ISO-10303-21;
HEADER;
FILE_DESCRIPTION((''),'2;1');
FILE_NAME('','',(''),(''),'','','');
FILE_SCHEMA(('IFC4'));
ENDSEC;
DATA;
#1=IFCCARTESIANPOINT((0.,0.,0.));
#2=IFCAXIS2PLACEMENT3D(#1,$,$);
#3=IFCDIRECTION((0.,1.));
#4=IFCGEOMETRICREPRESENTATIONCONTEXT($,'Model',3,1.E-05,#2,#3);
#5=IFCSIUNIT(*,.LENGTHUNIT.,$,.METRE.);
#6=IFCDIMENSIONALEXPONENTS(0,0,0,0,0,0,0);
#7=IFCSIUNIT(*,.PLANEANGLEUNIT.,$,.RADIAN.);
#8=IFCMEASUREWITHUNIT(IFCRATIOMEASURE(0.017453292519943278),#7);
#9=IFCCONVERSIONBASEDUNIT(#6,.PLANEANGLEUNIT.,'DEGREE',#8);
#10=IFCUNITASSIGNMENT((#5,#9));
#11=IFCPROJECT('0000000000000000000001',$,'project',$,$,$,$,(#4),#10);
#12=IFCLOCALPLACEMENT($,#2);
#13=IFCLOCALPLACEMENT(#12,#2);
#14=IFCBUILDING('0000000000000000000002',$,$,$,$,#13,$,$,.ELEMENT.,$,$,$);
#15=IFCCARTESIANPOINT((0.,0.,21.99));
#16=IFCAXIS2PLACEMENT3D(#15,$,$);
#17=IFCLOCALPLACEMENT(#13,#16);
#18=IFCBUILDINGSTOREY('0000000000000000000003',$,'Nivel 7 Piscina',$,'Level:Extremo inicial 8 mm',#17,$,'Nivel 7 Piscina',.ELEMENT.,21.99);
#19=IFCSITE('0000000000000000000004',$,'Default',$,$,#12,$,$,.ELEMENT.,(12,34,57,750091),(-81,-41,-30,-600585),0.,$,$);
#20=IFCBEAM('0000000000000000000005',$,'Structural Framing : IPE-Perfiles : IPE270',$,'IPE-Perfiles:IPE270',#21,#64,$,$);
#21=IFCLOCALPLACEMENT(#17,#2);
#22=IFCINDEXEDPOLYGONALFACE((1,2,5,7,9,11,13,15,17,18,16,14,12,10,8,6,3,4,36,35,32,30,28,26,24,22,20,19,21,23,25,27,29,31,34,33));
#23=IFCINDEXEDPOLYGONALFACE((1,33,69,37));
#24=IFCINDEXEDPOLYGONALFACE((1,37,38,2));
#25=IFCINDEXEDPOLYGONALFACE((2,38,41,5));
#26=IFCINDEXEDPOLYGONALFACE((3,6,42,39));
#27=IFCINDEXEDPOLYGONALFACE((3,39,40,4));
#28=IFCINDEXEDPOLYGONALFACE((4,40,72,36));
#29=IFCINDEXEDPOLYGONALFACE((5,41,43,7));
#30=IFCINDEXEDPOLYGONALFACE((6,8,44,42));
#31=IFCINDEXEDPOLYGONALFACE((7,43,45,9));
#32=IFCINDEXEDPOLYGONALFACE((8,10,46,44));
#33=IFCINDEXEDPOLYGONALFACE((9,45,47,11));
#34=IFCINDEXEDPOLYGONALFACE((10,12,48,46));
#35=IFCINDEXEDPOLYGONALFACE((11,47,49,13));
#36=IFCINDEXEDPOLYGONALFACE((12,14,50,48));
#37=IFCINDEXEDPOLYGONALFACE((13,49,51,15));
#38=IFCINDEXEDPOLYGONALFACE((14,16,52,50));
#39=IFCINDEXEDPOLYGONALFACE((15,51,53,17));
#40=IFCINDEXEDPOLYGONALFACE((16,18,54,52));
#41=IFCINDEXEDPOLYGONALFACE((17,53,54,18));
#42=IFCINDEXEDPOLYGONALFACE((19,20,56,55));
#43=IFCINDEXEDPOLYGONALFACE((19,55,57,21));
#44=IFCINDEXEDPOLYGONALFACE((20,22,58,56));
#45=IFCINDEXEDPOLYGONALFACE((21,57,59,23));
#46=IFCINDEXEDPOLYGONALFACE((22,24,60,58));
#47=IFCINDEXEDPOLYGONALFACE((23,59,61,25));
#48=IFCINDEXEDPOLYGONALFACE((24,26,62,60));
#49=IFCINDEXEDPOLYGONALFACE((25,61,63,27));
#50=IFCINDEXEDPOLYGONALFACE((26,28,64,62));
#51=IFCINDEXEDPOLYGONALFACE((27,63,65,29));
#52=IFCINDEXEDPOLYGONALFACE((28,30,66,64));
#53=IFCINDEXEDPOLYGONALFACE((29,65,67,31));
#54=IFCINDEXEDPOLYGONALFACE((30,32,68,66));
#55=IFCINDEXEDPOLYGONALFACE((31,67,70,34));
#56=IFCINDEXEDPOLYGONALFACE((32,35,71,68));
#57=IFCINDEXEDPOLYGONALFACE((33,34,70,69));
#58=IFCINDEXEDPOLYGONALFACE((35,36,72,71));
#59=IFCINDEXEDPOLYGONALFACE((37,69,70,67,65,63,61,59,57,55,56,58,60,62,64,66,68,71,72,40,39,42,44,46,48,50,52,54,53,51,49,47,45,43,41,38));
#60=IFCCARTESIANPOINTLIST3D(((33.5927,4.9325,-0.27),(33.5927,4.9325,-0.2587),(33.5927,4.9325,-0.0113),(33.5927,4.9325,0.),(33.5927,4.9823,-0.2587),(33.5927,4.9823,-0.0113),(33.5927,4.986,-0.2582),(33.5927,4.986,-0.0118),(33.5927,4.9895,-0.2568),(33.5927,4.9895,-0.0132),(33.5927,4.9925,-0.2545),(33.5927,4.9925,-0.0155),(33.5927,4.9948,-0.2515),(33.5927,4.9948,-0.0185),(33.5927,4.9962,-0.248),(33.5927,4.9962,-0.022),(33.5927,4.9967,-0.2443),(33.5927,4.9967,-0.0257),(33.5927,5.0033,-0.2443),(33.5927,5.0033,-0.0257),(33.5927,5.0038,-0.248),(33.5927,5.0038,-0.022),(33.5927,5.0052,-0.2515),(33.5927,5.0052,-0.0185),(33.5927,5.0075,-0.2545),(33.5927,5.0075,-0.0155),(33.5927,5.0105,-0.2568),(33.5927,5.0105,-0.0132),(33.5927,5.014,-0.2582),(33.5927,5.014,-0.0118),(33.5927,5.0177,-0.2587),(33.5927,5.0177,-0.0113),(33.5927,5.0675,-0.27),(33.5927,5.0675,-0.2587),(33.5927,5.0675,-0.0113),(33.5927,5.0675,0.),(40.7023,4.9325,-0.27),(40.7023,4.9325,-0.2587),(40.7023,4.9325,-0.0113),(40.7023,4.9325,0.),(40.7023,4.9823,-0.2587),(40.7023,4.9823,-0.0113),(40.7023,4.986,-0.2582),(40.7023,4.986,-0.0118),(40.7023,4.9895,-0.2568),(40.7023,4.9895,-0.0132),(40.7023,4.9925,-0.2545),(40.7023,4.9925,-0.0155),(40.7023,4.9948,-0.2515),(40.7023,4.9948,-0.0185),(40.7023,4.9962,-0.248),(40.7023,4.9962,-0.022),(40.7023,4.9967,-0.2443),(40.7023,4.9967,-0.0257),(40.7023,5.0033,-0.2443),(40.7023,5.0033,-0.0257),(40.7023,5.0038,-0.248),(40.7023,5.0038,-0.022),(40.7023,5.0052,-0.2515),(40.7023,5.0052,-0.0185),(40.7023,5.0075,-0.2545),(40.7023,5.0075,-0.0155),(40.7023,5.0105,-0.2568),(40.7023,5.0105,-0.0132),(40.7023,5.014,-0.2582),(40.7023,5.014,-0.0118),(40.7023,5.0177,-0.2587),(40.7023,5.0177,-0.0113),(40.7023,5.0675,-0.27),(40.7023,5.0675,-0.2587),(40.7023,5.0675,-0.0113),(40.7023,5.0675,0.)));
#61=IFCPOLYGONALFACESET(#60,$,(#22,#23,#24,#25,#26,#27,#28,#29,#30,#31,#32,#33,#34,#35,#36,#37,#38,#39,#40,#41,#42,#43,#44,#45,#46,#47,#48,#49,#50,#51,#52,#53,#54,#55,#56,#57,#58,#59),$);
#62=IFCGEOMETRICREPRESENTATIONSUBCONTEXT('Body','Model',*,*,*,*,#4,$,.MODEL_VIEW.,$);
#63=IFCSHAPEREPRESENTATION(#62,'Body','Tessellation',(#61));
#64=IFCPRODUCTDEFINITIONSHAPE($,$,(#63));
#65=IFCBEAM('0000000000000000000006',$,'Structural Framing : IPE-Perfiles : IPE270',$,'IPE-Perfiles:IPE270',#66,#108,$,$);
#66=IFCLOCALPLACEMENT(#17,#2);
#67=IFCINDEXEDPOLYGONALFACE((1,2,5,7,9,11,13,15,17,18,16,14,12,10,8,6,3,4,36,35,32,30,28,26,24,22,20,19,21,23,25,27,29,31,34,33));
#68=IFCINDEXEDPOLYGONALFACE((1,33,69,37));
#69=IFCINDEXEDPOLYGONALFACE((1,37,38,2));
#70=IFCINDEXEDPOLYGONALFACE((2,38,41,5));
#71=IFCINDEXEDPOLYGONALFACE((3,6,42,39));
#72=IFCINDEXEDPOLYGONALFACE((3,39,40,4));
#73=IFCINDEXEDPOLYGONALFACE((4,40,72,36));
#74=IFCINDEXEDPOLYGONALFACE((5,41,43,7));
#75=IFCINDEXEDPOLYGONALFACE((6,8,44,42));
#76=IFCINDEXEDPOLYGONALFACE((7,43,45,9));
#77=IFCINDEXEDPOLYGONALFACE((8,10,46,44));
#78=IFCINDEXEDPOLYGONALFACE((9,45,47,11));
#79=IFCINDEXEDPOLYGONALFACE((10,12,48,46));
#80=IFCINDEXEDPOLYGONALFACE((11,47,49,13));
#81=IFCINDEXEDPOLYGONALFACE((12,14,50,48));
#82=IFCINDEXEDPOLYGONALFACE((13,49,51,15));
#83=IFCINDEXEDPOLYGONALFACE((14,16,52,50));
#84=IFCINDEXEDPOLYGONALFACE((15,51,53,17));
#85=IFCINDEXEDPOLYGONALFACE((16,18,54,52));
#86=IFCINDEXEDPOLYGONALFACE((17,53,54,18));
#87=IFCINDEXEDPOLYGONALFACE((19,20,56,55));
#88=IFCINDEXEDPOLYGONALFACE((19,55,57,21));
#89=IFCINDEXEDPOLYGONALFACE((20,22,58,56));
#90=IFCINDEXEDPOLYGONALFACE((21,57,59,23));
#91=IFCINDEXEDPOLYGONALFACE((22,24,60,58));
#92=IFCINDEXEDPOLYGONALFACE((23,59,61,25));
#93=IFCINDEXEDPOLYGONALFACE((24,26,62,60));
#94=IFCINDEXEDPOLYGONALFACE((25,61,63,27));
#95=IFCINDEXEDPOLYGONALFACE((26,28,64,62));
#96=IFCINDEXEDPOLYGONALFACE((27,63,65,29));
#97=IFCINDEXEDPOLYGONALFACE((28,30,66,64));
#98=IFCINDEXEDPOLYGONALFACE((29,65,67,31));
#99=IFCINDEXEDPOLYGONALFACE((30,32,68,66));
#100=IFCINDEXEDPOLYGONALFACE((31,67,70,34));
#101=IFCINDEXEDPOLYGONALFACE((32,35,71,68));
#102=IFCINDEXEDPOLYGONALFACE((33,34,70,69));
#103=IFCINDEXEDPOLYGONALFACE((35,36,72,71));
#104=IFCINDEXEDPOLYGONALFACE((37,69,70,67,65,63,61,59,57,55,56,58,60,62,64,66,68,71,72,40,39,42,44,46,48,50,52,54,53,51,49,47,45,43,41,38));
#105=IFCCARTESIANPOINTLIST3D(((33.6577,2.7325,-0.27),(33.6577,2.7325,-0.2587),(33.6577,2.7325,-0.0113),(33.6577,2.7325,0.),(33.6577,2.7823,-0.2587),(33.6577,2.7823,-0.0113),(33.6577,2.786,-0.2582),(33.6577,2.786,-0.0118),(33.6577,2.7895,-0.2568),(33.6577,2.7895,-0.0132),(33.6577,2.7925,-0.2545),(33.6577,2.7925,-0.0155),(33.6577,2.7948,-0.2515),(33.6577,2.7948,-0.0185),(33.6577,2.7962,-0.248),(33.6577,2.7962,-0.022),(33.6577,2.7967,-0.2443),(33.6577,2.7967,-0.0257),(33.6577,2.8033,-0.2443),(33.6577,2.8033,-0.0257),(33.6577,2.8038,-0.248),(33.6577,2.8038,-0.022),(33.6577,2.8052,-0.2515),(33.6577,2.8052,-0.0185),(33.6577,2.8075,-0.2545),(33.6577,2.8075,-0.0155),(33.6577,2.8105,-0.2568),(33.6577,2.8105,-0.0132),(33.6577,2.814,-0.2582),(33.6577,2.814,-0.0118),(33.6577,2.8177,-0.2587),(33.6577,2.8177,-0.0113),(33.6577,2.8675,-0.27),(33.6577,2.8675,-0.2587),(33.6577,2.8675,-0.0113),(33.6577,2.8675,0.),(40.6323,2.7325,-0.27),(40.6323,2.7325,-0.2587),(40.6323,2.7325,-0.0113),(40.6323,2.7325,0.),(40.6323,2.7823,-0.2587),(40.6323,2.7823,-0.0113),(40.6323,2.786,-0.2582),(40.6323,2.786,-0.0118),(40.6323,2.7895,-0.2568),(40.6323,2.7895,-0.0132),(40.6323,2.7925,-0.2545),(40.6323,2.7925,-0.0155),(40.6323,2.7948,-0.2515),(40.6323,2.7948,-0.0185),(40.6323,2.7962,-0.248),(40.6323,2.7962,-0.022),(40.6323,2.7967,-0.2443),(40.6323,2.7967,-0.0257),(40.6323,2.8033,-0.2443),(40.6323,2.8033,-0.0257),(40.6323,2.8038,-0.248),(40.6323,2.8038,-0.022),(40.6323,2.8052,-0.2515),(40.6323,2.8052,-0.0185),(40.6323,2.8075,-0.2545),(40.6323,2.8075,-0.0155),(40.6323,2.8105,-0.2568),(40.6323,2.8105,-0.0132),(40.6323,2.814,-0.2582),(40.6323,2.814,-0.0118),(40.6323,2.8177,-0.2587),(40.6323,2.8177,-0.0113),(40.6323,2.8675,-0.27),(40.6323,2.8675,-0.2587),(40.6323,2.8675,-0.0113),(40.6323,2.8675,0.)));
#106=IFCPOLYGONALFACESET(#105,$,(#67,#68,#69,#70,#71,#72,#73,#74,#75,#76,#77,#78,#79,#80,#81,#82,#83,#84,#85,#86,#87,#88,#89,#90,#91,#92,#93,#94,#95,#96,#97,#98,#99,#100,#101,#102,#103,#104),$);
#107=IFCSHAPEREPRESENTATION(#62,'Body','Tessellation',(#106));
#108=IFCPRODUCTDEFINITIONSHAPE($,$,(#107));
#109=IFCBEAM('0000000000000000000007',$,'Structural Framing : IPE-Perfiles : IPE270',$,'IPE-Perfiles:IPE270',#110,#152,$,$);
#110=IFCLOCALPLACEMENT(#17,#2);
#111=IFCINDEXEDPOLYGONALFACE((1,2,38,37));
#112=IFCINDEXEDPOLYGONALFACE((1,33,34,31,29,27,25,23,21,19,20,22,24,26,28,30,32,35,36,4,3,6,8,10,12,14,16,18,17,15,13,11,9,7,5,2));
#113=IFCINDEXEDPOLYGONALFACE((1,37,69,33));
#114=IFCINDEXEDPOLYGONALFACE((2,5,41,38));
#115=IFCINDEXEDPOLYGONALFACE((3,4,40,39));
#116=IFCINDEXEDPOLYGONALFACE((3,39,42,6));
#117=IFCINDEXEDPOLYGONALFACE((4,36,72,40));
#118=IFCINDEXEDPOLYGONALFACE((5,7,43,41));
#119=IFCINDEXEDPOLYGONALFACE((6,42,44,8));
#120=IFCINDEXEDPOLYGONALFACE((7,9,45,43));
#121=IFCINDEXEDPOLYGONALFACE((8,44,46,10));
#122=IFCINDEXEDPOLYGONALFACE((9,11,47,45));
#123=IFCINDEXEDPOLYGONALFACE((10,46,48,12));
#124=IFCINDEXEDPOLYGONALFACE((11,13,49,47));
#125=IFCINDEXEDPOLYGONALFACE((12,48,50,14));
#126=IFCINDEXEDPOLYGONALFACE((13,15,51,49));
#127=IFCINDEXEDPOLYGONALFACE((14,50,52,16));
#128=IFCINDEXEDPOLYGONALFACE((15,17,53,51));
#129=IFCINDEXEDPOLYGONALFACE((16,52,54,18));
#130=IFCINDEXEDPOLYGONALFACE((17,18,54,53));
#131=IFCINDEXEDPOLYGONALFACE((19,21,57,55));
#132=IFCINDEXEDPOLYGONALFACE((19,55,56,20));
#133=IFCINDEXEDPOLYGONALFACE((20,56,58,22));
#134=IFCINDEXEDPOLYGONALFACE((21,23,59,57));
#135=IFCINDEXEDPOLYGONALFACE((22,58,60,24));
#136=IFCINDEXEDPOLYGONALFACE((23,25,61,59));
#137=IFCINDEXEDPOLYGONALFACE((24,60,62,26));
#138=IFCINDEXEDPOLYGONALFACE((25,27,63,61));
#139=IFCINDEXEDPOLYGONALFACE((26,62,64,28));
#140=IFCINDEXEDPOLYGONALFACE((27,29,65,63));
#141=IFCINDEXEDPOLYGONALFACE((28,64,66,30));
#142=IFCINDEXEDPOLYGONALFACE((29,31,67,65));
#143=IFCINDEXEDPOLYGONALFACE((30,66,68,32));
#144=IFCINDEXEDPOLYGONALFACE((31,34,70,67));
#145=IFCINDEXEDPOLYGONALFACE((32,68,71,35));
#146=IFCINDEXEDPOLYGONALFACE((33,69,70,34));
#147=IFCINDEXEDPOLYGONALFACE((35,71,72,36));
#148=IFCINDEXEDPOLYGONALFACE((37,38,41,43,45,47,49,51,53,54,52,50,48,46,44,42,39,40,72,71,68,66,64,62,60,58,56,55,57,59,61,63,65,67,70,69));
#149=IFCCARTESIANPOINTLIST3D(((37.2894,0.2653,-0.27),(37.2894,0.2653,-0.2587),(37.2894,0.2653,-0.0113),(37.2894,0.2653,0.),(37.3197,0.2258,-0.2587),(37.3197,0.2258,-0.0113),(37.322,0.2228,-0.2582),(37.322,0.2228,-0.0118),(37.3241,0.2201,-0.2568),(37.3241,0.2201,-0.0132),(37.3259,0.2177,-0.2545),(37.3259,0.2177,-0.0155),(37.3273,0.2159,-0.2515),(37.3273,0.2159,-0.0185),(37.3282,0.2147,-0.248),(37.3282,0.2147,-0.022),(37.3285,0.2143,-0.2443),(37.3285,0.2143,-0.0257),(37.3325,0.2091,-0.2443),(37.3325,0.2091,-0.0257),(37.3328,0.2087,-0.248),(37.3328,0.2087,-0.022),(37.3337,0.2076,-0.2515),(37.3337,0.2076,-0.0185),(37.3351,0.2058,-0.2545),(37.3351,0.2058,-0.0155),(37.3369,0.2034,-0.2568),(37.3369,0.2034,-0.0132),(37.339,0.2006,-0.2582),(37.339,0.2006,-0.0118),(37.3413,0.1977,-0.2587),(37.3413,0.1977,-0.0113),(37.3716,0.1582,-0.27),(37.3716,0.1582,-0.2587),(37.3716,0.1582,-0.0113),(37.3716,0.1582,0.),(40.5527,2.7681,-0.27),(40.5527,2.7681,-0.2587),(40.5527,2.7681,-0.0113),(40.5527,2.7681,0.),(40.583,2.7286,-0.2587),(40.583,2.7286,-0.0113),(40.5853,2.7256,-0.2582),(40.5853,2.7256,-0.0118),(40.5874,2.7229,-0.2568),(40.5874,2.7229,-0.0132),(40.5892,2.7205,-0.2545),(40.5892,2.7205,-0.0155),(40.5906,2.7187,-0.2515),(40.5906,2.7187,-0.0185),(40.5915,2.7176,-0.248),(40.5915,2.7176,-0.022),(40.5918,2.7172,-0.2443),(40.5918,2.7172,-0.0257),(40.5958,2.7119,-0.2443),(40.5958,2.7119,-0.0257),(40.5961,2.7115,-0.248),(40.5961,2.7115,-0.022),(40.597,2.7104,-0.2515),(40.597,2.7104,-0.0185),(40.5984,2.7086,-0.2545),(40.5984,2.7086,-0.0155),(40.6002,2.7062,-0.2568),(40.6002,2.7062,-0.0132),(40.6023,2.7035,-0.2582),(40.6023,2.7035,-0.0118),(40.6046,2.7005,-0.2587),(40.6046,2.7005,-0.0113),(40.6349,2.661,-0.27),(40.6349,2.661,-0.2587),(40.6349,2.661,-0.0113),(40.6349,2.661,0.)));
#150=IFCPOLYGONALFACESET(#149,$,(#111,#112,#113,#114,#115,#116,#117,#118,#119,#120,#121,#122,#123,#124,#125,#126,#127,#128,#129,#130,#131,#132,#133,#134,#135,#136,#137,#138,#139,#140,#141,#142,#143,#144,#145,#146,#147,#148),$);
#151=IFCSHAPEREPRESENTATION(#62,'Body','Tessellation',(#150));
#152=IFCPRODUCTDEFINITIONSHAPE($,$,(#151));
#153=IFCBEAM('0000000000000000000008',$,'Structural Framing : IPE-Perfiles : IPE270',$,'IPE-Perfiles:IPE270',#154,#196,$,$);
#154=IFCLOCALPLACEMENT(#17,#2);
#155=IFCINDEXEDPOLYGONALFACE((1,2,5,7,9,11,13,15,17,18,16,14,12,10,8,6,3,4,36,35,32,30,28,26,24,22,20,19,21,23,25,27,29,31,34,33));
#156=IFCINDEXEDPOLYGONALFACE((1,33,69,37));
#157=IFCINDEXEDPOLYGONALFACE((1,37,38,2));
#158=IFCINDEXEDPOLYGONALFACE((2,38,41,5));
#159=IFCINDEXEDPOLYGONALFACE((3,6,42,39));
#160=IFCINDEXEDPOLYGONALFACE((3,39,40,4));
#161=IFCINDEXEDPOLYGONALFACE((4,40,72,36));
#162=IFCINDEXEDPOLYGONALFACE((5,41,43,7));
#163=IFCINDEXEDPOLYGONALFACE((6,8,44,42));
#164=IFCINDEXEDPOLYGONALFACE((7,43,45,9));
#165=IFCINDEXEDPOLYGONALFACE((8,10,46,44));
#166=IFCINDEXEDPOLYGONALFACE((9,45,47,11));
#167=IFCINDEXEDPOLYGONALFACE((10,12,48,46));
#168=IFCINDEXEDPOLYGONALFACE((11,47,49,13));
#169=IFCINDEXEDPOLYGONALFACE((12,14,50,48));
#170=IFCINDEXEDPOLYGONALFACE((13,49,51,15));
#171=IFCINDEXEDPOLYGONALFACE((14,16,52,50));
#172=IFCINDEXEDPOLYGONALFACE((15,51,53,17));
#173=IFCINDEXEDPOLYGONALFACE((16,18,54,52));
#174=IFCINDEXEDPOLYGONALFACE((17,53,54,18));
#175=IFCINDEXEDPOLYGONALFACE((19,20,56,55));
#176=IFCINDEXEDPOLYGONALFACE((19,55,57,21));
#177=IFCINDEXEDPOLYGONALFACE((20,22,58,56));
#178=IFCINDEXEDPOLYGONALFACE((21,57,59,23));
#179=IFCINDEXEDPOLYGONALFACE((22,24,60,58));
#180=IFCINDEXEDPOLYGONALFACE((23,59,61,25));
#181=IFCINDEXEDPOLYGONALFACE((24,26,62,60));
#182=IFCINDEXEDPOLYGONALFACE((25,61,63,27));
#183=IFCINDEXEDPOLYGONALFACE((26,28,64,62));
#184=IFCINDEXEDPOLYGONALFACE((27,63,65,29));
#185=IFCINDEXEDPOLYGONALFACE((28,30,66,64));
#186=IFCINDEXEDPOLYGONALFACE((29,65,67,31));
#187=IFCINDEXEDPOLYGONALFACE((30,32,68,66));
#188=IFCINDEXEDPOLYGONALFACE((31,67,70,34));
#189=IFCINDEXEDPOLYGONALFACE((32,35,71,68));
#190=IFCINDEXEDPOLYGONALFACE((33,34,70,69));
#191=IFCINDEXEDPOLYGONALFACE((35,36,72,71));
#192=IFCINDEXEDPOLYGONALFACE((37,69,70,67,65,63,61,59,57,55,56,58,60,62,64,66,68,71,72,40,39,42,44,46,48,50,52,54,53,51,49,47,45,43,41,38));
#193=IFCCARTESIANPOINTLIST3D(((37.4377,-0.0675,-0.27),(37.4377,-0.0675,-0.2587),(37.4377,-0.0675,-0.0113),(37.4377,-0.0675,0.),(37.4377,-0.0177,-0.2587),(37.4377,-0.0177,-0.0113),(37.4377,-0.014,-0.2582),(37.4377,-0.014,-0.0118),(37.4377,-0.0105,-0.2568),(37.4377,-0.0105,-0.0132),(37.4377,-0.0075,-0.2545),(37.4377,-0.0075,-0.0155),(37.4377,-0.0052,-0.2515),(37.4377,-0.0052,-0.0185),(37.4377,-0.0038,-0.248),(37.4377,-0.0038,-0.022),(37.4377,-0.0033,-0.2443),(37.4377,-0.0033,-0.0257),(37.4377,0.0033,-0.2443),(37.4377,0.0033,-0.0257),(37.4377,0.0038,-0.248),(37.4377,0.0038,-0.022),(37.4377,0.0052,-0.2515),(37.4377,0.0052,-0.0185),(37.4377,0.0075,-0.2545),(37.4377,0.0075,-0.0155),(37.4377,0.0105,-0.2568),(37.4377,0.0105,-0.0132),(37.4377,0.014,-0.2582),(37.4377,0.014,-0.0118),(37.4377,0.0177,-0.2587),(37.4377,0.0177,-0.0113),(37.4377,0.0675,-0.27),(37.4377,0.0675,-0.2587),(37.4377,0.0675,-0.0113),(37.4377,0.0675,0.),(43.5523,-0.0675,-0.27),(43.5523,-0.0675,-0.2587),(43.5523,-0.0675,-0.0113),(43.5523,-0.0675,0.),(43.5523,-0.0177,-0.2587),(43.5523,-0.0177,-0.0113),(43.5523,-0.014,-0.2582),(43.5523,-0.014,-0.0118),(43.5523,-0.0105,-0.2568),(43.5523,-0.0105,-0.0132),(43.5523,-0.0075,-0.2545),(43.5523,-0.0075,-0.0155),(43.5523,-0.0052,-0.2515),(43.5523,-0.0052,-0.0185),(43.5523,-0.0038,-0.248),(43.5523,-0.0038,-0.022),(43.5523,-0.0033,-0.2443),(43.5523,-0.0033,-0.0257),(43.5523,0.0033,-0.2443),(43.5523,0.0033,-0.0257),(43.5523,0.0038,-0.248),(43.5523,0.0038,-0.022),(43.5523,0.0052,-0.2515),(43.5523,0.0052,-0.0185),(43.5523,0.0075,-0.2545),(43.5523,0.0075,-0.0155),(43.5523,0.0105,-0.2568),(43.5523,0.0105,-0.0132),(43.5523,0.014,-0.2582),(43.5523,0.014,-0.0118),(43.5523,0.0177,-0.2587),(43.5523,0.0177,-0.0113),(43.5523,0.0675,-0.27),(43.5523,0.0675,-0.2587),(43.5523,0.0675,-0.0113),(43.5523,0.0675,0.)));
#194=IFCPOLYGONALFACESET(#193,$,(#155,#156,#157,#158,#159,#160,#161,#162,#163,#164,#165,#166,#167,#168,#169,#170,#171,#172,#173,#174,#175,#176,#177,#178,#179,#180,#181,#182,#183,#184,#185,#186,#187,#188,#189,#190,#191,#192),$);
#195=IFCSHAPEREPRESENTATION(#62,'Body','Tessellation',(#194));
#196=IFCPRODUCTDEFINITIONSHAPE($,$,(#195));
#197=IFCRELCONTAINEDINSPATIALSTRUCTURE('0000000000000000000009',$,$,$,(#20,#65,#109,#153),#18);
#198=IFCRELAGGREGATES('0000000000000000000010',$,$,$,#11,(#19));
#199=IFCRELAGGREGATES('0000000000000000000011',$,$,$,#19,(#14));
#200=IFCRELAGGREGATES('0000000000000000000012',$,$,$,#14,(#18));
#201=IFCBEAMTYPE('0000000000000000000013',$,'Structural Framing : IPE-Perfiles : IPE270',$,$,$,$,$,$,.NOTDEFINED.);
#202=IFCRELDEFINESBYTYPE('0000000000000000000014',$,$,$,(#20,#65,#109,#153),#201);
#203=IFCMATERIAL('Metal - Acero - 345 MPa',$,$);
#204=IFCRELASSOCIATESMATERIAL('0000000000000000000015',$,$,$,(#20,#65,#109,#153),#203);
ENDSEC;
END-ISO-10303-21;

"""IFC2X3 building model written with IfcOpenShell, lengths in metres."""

from ifc_helpers import new_model, entity, si_unit, converted_unit, direction, frame, frame_2d, origin, place, context, subcontext, project, spatial, i_section, extrude, material, type_object, element, save


model = new_model("IFC2X3")

# Units and contexts
model_context = context("Model", 3, precision=1e-05, world=origin(), true_north=direction((0.0, 1.0)))
body_context = subcontext(model_context, "Body", "Model", "MODEL_VIEW")
ifc_project = project(units=[si_unit("LENGTHUNIT", "METRE"), converted_unit("PLANEANGLEUNIT", "DEGREE", entity("IfcRatioMeasure", 0.017453292519943278), si_unit("PLANEANGLEUNIT", "RADIAN"), dimensions=[0, 0, 0, 0, 0, 0, 0])], contexts=[model_context])

# Site, building, storey
site_placement = place(None, origin())
site = spatial("IfcSite", under=ifc_project, at=site_placement, Name="Default", CompositionType="ELEMENT", RefLatitude=(12, 34, 57, 750091), RefLongitude=(-81, -41, -30, -600585), RefElevation=0.0)
building_placement = place(site_placement, origin())
building = spatial("IfcBuilding", under=site, at=building_placement, CompositionType="ELEMENT")
storey_placement = place(building_placement, frame((0.0, 0.0, 21.99)))
storey = spatial("IfcBuildingStorey", under=building, at=storey_placement, Name="Nivel 7 Piscina", ObjectType="Level:Extremo inicial 8 mm", LongName="Nivel 7 Piscina", CompositionType="ELEMENT", Elevation=21.99)

# Shared definitions
ifc_material = material(Name="Metal - Acero - 345 MPa")

# Beams
beam_type_1 = type_object("IfcBeamType", Name="Structural Framing : IPE-Perfiles : IPE270", PredefinedType="NOTDEFINED")
beam_1_placement = place(storey_placement, frame((33.495, 5.0, 0.0)))
element("IfcBeam", 1, at=beam_1_placement, inside=storey, type_object=beam_type_1, material=ifc_material, Name="Structural Framing : IPE-Perfiles : IPE270", ObjectType="IPE-Perfiles:IPE270", context=body_context, shape_type="SweptSolid", body=[
    extrude(i_section(OverallWidth=0.135, OverallDepth=0.27, WebThickness=0.0066, FlangeThickness=0.0113, FilletRadius=0.0144, at=frame_2d((0.0, 0.0), x_axis=(0.0, 1.0))), frame((0.0977, 0.0, -0.135), z_axis=(1.0, 0.0, 0.0), x_axis=(0.0, 0.0, -1.0)), (0.0, 0.0, 1.0), 7.1096),
])
beam_2_placement = place(storey_placement, frame((33.495, 2.8, 0.0)))
element("IfcBeam", 2, at=beam_2_placement, inside=storey, type_object=beam_type_1, material=ifc_material, Name="Structural Framing : IPE-Perfiles : IPE270", ObjectType="IPE-Perfiles:IPE270", context=body_context, shape_type="SweptSolid", body=[
    extrude(i_section(OverallWidth=0.135, OverallDepth=0.27, WebThickness=0.0066, FlangeThickness=0.0113, FilletRadius=0.0144, at=frame_2d((0.0, 0.0), x_axis=(0.0, 1.0))), frame((0.1627, 0.0, -0.135), z_axis=(1.0, 0.0, 0.0), x_axis=(0.0, 0.0, -1.0)), (0.0, 0.0, 1.0), 6.9746),
])
beam_3_placement = place(storey_placement, frame((37.25, 0.15, 0.0), z_axis=(0.0, 0.0, 1.0), x_axis=(0.793497, 0.608574, 0.0)))
element("IfcBeam", 3, at=beam_3_placement, inside=storey, type_object=beam_type_1, material=ifc_material, Name="Structural Framing : IPE-Perfiles : IPE270", ObjectType="IPE-Perfiles:IPE270", context=body_context, shape_type="SweptSolid", body=[
    extrude(i_section(OverallWidth=0.135, OverallDepth=0.27, WebThickness=0.0066, FlangeThickness=0.0113, FilletRadius=0.0144, at=frame_2d((0.0, 0.0), x_axis=(0.0, 1.0))), frame((0.1014, 0.0, -0.135), z_axis=(1.0, 0.0, 0.0), x_axis=(0.0, 0.0, -1.0)), (0.0, 0.0, 1.0), 4.1126),
])
beam_4_placement = place(storey_placement, frame((37.445, 0.0, 0.0)))
element("IfcBeam", 4, at=beam_4_placement, inside=storey, type_object=beam_type_1, material=ifc_material, Name="Structural Framing : IPE-Perfiles : IPE270", ObjectType="IPE-Perfiles:IPE270", context=body_context, shape_type="SweptSolid", body=[
    extrude(i_section(OverallWidth=0.135, OverallDepth=0.27, WebThickness=0.0066, FlangeThickness=0.0113, FilletRadius=0.0144, at=frame_2d((0.0, 0.0), x_axis=(0.0, 1.0))), frame((-0.0073, 0.0, -0.135), z_axis=(1.0, 0.0, 0.0), x_axis=(0.0, 0.0, -1.0)), (0.0, 0.0, 1.0), 6.1146),
])

save(model, "model.ifc")
